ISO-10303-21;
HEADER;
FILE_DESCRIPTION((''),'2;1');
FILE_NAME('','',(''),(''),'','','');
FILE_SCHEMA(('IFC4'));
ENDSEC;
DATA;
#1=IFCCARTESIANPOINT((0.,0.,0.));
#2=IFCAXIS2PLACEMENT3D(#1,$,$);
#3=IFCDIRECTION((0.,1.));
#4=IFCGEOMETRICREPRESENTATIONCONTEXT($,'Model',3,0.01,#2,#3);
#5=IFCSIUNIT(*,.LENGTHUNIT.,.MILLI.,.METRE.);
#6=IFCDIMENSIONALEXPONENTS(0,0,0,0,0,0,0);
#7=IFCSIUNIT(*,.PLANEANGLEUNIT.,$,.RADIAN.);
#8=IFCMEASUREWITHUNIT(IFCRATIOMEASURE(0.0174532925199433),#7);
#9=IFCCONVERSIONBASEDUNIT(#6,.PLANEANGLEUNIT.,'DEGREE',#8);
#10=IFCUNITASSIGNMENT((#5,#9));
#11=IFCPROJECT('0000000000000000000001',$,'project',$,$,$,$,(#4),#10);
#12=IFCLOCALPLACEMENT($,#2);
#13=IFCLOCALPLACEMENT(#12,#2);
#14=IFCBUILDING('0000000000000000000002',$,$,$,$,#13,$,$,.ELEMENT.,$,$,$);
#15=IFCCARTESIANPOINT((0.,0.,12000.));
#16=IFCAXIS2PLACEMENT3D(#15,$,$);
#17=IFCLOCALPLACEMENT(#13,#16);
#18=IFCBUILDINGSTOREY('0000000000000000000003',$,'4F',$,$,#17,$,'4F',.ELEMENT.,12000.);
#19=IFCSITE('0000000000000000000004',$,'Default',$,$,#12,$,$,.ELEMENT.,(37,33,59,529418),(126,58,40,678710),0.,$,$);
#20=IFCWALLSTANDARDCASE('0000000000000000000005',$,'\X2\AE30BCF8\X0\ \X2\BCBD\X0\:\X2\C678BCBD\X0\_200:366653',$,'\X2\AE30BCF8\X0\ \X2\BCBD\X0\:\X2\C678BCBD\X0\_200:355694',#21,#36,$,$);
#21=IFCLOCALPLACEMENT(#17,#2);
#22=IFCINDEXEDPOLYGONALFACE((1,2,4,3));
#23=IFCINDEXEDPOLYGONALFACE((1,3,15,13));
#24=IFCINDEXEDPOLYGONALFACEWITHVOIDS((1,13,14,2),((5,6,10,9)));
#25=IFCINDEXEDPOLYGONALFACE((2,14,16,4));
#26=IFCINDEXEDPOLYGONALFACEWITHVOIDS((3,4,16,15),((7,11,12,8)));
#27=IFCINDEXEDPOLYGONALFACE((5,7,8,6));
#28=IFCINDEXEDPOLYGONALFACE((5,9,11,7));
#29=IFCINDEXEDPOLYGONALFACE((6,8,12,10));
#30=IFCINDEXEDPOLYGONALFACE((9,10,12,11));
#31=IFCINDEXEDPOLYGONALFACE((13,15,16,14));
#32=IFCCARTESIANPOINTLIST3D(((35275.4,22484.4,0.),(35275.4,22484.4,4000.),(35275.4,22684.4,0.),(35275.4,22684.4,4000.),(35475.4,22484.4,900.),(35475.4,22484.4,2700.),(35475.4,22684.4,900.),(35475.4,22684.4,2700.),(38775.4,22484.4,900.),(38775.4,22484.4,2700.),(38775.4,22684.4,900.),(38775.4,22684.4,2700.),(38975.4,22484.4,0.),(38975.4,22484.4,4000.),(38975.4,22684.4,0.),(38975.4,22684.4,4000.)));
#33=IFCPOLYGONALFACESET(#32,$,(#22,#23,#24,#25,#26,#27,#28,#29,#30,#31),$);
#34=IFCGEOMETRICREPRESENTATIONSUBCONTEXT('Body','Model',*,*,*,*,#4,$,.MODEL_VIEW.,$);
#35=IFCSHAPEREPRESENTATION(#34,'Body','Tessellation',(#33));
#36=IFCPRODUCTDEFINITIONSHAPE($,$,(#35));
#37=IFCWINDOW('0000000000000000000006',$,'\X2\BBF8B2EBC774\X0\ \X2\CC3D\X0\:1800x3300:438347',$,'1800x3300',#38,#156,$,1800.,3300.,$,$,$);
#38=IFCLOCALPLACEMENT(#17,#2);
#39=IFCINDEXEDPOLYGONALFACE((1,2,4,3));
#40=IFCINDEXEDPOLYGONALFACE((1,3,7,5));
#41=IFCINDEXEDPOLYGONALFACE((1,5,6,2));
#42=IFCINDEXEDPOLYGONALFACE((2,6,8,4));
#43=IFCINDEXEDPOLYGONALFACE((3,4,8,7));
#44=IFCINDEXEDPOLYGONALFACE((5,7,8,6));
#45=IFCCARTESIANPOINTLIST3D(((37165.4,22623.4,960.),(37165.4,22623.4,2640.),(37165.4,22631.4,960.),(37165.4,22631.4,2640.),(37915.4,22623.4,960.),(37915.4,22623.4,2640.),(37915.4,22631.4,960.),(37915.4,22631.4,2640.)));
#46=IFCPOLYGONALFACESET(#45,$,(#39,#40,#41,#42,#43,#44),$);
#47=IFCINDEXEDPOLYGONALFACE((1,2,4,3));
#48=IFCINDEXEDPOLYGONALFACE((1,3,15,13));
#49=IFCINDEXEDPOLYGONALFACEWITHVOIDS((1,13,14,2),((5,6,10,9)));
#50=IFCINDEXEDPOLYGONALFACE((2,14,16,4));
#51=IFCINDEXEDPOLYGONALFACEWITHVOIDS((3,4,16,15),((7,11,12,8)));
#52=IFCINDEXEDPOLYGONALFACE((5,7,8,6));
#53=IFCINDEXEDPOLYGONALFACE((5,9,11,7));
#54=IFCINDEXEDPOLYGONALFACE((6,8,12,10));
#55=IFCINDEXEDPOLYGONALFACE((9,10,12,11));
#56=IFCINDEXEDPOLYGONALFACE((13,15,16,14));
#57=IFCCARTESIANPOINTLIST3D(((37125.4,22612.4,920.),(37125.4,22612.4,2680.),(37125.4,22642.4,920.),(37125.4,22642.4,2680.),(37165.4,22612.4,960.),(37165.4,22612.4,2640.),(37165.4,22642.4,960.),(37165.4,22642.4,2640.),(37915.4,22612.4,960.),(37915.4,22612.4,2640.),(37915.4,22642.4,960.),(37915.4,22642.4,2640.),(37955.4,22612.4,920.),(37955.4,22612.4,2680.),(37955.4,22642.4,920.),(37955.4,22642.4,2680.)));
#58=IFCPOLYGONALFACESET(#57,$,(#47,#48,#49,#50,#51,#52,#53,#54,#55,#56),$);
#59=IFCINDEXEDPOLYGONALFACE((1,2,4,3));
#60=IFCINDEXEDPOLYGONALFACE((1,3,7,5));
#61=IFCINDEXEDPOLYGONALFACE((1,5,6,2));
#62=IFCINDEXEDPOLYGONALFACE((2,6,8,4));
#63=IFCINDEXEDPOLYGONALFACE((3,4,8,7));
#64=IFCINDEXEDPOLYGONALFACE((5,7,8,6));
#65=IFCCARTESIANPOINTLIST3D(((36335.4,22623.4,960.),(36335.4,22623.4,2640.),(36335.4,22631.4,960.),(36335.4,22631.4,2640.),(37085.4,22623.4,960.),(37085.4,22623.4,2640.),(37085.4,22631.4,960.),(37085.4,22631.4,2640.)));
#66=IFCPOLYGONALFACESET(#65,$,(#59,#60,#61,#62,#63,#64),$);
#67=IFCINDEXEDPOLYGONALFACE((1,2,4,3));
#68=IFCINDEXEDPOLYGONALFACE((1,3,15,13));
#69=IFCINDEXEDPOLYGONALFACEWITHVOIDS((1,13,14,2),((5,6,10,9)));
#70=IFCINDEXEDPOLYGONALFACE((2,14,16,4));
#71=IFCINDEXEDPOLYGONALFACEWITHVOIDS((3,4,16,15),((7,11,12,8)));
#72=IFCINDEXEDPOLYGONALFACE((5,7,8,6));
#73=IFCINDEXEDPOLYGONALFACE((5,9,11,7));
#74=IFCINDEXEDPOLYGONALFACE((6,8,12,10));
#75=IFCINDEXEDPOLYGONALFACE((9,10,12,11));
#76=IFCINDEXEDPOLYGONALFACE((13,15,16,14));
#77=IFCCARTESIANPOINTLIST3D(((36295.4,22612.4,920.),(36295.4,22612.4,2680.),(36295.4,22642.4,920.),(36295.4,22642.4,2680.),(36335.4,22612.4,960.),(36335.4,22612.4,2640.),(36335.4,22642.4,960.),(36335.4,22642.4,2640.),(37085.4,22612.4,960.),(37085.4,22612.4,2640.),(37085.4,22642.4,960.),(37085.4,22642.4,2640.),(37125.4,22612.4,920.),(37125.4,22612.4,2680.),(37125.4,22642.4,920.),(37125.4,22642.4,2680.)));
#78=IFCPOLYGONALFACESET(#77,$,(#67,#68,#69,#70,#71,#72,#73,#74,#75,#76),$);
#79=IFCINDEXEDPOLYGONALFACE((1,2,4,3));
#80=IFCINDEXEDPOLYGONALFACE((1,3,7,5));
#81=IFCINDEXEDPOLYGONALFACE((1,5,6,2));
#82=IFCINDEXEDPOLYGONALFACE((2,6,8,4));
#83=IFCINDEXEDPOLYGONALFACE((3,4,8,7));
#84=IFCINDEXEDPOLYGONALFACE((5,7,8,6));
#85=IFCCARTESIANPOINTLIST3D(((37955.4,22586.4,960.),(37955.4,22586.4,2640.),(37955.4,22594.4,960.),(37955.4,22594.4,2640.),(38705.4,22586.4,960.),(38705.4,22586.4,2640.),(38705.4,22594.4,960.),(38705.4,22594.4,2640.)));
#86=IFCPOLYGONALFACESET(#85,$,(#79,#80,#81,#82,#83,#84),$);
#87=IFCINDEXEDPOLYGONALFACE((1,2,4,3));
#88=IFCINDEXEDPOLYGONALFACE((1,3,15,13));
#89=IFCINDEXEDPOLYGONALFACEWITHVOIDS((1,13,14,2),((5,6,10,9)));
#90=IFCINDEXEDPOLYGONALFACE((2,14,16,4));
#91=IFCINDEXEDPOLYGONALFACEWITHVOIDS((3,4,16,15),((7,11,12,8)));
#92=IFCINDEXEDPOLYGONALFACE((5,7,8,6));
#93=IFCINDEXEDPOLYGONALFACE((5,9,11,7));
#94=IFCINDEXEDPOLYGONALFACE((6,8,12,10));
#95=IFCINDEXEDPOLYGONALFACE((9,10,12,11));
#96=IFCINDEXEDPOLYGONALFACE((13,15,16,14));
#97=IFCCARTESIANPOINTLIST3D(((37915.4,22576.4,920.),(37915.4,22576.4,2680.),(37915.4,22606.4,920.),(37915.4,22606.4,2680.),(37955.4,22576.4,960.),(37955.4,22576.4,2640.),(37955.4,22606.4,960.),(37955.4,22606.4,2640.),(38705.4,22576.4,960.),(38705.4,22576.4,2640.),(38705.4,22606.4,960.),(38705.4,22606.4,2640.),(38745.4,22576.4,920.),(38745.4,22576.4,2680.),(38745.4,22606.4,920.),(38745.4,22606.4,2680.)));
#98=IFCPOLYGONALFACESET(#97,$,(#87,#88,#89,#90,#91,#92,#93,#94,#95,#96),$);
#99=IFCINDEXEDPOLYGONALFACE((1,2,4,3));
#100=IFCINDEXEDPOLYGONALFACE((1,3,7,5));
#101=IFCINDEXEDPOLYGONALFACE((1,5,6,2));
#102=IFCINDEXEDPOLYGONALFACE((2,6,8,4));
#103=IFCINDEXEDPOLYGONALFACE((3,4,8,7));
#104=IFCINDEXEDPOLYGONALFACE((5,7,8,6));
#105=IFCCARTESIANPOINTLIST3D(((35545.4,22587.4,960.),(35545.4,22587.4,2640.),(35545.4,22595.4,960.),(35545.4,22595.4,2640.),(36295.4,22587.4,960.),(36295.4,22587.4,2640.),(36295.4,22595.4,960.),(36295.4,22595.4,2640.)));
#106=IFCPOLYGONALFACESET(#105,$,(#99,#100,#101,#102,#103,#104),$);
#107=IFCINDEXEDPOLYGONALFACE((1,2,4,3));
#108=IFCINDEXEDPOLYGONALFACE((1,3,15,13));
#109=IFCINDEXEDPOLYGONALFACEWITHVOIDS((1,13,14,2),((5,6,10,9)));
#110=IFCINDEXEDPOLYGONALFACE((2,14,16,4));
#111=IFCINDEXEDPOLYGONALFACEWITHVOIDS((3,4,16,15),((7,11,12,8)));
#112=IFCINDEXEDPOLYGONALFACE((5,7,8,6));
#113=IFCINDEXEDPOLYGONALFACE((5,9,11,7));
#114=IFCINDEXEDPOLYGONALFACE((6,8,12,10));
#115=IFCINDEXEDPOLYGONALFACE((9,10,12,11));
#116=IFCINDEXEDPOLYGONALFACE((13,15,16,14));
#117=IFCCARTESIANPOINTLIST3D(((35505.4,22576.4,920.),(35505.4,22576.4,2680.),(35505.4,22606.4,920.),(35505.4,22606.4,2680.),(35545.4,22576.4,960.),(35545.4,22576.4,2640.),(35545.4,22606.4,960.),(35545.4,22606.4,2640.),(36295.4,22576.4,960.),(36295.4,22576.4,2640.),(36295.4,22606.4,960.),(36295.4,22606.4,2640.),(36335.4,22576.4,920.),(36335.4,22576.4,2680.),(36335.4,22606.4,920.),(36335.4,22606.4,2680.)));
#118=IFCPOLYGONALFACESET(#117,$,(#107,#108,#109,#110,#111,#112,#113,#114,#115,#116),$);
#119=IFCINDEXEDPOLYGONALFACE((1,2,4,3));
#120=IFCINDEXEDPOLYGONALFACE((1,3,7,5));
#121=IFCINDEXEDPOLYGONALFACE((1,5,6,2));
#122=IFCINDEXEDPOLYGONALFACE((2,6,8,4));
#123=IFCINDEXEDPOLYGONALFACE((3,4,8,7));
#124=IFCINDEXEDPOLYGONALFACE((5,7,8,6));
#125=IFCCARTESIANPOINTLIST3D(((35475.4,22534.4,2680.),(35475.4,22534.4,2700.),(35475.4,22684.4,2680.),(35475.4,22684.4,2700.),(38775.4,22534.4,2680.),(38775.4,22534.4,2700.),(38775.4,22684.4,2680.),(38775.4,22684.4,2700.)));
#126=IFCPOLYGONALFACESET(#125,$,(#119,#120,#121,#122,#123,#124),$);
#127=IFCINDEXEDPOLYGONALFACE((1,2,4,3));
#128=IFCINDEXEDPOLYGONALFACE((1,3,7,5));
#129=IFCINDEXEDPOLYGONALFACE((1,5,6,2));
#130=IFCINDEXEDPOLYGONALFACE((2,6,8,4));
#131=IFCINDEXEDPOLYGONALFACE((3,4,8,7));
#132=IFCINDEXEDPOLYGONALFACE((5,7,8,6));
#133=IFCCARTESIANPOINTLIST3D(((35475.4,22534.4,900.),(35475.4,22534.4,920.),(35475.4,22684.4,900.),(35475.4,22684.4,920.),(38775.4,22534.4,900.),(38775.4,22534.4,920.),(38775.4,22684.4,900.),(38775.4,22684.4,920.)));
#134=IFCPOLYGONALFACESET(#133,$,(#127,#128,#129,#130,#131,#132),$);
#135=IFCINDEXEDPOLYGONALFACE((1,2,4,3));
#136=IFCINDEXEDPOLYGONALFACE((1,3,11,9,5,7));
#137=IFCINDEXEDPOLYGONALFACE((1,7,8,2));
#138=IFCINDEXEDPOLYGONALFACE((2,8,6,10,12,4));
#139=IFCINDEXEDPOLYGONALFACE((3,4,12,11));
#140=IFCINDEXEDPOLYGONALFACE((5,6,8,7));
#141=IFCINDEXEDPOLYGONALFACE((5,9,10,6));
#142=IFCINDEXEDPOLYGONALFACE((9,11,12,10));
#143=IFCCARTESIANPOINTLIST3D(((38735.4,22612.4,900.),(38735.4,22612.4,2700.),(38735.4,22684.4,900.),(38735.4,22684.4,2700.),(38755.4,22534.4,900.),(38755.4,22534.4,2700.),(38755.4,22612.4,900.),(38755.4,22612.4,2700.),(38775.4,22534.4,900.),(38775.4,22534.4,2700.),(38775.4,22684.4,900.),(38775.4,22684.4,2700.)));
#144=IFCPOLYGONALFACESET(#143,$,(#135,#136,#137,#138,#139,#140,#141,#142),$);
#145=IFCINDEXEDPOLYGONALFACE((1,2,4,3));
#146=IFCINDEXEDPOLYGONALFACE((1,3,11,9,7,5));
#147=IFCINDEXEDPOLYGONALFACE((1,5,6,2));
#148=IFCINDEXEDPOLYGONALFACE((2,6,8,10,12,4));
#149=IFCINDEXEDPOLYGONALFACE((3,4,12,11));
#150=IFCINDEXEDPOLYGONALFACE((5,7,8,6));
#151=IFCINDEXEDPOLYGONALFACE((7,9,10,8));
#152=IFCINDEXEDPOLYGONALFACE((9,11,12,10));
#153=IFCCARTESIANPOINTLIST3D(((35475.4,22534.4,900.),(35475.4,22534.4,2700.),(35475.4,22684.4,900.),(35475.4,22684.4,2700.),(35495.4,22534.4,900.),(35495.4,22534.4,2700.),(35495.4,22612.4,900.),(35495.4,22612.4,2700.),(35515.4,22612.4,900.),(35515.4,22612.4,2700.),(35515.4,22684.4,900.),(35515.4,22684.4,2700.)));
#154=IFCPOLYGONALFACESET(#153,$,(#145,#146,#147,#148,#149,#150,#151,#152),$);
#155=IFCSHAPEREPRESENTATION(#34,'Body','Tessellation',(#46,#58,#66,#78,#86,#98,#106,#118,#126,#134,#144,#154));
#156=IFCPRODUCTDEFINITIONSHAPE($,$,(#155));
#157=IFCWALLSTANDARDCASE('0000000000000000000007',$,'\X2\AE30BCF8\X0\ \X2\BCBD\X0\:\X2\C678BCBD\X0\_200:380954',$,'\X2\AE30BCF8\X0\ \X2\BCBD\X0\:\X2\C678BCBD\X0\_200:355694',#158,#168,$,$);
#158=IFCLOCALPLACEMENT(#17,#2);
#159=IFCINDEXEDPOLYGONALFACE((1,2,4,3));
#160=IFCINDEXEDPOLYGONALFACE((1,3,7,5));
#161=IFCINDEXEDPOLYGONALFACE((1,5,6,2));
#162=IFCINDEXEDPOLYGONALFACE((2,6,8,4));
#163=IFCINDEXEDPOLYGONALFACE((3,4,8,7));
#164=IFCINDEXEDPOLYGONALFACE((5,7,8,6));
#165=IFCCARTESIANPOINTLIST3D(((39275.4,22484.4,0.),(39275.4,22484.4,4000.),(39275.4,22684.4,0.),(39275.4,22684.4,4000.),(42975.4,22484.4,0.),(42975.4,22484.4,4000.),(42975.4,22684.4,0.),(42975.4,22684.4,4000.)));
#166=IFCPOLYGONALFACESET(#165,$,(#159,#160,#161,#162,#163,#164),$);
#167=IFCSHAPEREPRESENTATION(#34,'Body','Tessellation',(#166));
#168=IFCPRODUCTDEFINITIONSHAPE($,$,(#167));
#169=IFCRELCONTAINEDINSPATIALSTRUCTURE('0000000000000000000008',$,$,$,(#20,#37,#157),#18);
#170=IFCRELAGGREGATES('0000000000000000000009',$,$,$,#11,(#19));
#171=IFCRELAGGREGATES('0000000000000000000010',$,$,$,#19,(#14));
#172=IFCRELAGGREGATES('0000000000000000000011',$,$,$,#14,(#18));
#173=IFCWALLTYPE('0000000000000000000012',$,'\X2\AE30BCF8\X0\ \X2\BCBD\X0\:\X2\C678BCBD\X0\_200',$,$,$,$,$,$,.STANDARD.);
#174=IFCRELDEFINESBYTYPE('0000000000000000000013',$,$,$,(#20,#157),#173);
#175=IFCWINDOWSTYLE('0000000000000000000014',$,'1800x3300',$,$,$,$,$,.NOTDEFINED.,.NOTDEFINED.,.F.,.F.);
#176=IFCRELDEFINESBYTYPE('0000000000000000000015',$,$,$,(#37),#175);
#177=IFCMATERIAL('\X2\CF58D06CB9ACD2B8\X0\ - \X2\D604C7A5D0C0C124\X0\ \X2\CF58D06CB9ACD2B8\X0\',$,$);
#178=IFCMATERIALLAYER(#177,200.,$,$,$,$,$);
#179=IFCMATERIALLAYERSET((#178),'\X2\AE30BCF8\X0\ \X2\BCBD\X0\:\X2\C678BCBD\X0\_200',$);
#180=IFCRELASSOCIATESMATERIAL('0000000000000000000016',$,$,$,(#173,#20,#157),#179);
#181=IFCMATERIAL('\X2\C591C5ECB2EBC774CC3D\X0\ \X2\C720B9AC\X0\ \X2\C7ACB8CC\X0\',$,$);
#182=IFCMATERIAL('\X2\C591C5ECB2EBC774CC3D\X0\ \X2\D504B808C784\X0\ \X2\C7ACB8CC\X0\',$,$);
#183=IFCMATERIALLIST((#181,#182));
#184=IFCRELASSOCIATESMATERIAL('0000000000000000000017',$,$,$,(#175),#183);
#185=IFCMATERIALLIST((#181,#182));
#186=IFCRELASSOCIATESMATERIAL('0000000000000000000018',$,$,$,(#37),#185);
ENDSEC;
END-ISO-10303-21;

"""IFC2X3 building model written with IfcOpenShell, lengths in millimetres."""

from ifc_helpers import new_model, entity, si_unit, converted_unit, direction, frame, frame_2d, origin, origin_2d_with_axis, place, context, subcontext, project, spatial, polyline, rectangle, outline, extrude, source, transform, mapped, material, material_list, layer, layer_set, layer_usage, type_object, type_shapes, element, fill, save


model = new_model("IFC2X3")

# Units and contexts
model_context = context("Model", 3, precision=0.01, world=origin(), true_north=direction((0.0, 1.0)))
body_context = subcontext(model_context, "Body", "Model", "MODEL_VIEW")
ifc_project = project(units=[si_unit("LENGTHUNIT", "METRE", prefix="MILLI"), converted_unit("PLANEANGLEUNIT", "DEGREE", entity("IfcRatioMeasure", 0.0174532925199433), si_unit("PLANEANGLEUNIT", "RADIAN"), dimensions=[0, 0, 0, 0, 0, 0, 0])], contexts=[model_context])

# Site, building, storey
site_placement = place(None, origin())
site = spatial("IfcSite", under=ifc_project, at=site_placement, Name="Default", CompositionType="ELEMENT", RefLatitude=(37, 33, 59, 529418), RefLongitude=(126, 58, 40, 678710), RefElevation=0.0)
building_placement = place(site_placement, origin())
building = spatial("IfcBuilding", under=site, at=building_placement, CompositionType="ELEMENT")
storey_placement = place(building_placement, frame((0.0, 0.0, 12000.0)))
storey = spatial("IfcBuildingStorey", under=building, at=storey_placement, Name="4F", LongName="4F", CompositionType="ELEMENT", Elevation=12000.0)

# Shared definitions
ifc_material_1 = material(Name="콘크리트 - 현장타설 콘크리트")
ifc_material_2 = material(Name="양여닫이창 유리 재료")
ifc_material_3 = material(Name="양여닫이창 프레임 재료")

# Shared definitions
ifc_layer_1 = layer(ifc_material_1, 200.0)
ifc_layer_set_1 = layer_set([ifc_layer_1], Name="기본 벽:외벽_200")
wall_type_1 = type_object("IfcWallType", Name="기본 벽:외벽_200", PredefinedType="STANDARD", material=ifc_layer_set_1)

# Wall, opening, window
ifc_layer_usage_1 = layer_usage(ifc_layer_set_1, "AXIS2", "NEGATIVE", 100.0)
wall_1_placement = place(storey_placement, frame((38975.4, 22584.4, 0.0), z_axis=(0.0, 0.0, 1.0), x_axis=(-1.0, 0.0, 0.0)))
wall_1 = element("IfcWallStandardCase", 1, at=wall_1_placement, inside=storey, type_object=wall_type_1, material=ifc_layer_usage_1, Name="기본 벽:외벽_200:366653", ObjectType="기본 벽:외벽_200:355694", context=body_context, shape_type="SweptSolid", body=[
    extrude(rectangle(XDim=3700.0, YDim=200.0, at=frame_2d((1850.0, 0.0), x_axis=(-1.0, 0.0))), origin(), (0.0, 0.0, 1.0), 4000.0),
])
opening_1_placement = place(wall_1_placement, frame((3500.0, 100.0, 900.0)))
opening_1 = element("IfcOpeningElement", 2, at=opening_1_placement, cuts=wall_1, ObjectType="Opening", context=body_context, shape_type="SweptSolid", body=[
    extrude(rectangle(XDim=1800.0, YDim=3300.0, at=frame_2d((900.0, 1650.0), x_axis=(1.0, 0.0))), frame((0.0, 0.0, 0.0), z_axis=(0.0, -1.0, 0.0), x_axis=(0.0, 0.0, 1.0)), (0.0, 0.0, 1.0), 200.0),
])
ifc_material_list_1 = material_list([ifc_material_2, ifc_material_3])
ifc_material_list_2 = material_list([ifc_material_2, ifc_material_3])
window_style_1 = type_object("IfcWindowStyle", Name="1800x3300", ConstructionType="NOTDEFINED", OperationType="NOTDEFINED", ParameterTakesPrecedence=False, Sizeable=False, material=ifc_material_list_2)
shared_shape_1 = source(origin(), body_context, "Body", "SweptSolid", [
    extrude(rectangle(XDim=8.0, YDim=750.0, at=frame_2d((0.0, 0.0), x_axis=(1.0, 0.0))), frame((2065.0, 143.0, 60.0), z_axis=(0.0, 0.0, 1.0), x_axis=(0.0, 1.0, 0.0)), (0.0, 0.0, 1.0), 1680.0),
    extrude(outline(polyline([(-880.0, -415.0), (880.0, -415.0), (880.0, 415.0), (-880.0, 415.0), (-880.0, -415.0)]), holes=[polyline([(840.0, -375.0), (-840.0, -375.0), (-840.0, 375.0), (840.0, 375.0), (840.0, -375.0)])]), frame((2065.0, 128.0, 900.0), z_axis=(0.0, 1.0, 0.0), x_axis=(0.0, 0.0, -1.0)), (0.0, 0.0, 1.0), 30.0),
    extrude(rectangle(XDim=8.0, YDim=750.0, at=frame_2d((0.0, 0.0), x_axis=(1.0, 0.0))), frame((1235.0, 143.0, 60.0), z_axis=(0.0, 0.0, 1.0), x_axis=(0.0, 1.0, 0.0)), (0.0, 0.0, 1.0), 1680.0),
    extrude(outline(polyline([(-880.0, -415.0), (880.0, -415.0), (880.0, 415.0), (-880.0, 415.0), (-880.0, -415.0)]), holes=[polyline([(840.0, -375.0), (-840.0, -375.0), (-840.0, 375.0), (840.0, 375.0), (840.0, -375.0)])]), frame((1235.0, 128.0, 900.0), z_axis=(0.0, 1.0, 0.0), x_axis=(0.0, 0.0, -1.0)), (0.0, 0.0, 1.0), 30.0),
    extrude(rectangle(XDim=8.0, YDim=750.0, at=frame_2d((0.0, 0.0), x_axis=(1.0, 0.0))), frame((2855.0, 106.0, 60.0), z_axis=(0.0, 0.0, 1.0), x_axis=(0.0, 1.0, 0.0)), (0.0, 0.0, 1.0), 1680.0),
    extrude(outline(polyline([(-880.0, -415.0), (880.0, -415.0), (880.0, 415.0), (-880.0, 415.0), (-880.0, -415.0)]), holes=[polyline([(840.0, -375.0), (-840.0, -375.0), (-840.0, 375.0), (840.0, 375.0), (840.0, -375.0)])]), frame((2855.0, 92.0, 900.0), z_axis=(0.0, 1.0, 0.0), x_axis=(0.0, 0.0, -1.0)), (0.0, 0.0, 1.0), 30.0),
    extrude(rectangle(XDim=8.0, YDim=750.0, at=origin_2d_with_axis()), frame((445.0, 107.0, 60.0), z_axis=(0.0, 0.0, 1.0), x_axis=(0.0, 1.0, 0.0)), (0.0, 0.0, 1.0), 1680.0),
    extrude(outline(polyline([(-880.0, -415.0), (880.0, -415.0), (880.0, 415.0), (-880.0, 415.0), (-880.0, -415.0)]), holes=[polyline([(840.0, -375.0), (-840.0, -375.0), (-840.0, 375.0), (840.0, 375.0), (840.0, -375.0)])]), frame((445.0, 92.0, 900.0), z_axis=(0.0, 1.0, 0.0), x_axis=(0.0, 0.0, -1.0)), (0.0, 0.0, 1.0), 30.0),
    extrude(rectangle(XDim=3300.0, YDim=150.0, at=origin_2d_with_axis()), frame((1650.0, 125.0, 1780.0), z_axis=(0.0, 0.0, 1.0), x_axis=(-1.0, 0.0, 0.0)), (0.0, 0.0, 1.0), 20.0),
    extrude(rectangle(XDim=3300.0, YDim=150.0, at=origin_2d_with_axis()), frame((1650.0, 125.0, 0.0), z_axis=(0.0, 0.0, 1.0), x_axis=(-1.0, 0.0, 0.0)), (0.0, 0.0, 1.0), 20.0),
    extrude(outline(polyline([(-74.0, -20.0), (-2.0, -20.0), (-2.0, 0.0), (76.0, 0.0), (76.0, 20.0), (-74.0, 20.0), (-74.0, -20.0)])), frame((3280.0, 126.0, 0.0), z_axis=(0.0, 0.0, 1.0), x_axis=(0.0, -1.0, 0.0)), (0.0, 0.0, 1.0), 1800.0),
    extrude(outline(polyline([(-20.0, -74.0), (20.0, -74.0), (20.0, 76.0), (0.0, 76.0), (0.0, -2.0), (-20.0, -2.0), (-20.0, -74.0)])), frame((20.0, 126.0, 0.0), z_axis=(0.0, 0.0, 1.0), x_axis=(-1.0, 0.0, 0.0)), (0.0, 0.0, 1.0), 1800.0),
])
type_shapes(window_style_1, [shared_shape_1])
window_1_placement = place(opening_1_placement, frame((0.0, 0.0, 0.0), z_axis=(0.0, 0.0, 1.0), x_axis=(-1.0, 0.0, 0.0)))
window_1 = element("IfcWindow", 3, at=window_1_placement, inside=storey, type_object=window_style_1, material=ifc_material_list_1, Name="미닫이 창:1800x3300:438347", ObjectType="1800x3300", OverallHeight=1800.0, OverallWidth=3300.0, context=body_context, shape_type="MappedRepresentation", body=[
    mapped(shared_shape_1, transform((0.0, 0.0, 0.0), scale=1.0)),
])
fill(opening_1, window_1)

# Wall
ifc_layer_usage_2 = layer_usage(ifc_layer_set_1, "AXIS2", "NEGATIVE", 100.0)
wall_2_placement = place(storey_placement, frame((39275.4, 22584.4, 0.0)))
element("IfcWallStandardCase", 4, at=wall_2_placement, inside=storey, type_object=wall_type_1, material=ifc_layer_usage_2, Name="기본 벽:외벽_200:380954", ObjectType="기본 벽:외벽_200:355694", context=body_context, shape_type="SweptSolid", body=[
    extrude(rectangle(XDim=3700.0, YDim=200.0, at=frame_2d((1850.0, 0.0), x_axis=(-1.0, 0.0))), origin(), (0.0, 0.0, 1.0), 4000.0),
])

save(model, "model.ifc")
